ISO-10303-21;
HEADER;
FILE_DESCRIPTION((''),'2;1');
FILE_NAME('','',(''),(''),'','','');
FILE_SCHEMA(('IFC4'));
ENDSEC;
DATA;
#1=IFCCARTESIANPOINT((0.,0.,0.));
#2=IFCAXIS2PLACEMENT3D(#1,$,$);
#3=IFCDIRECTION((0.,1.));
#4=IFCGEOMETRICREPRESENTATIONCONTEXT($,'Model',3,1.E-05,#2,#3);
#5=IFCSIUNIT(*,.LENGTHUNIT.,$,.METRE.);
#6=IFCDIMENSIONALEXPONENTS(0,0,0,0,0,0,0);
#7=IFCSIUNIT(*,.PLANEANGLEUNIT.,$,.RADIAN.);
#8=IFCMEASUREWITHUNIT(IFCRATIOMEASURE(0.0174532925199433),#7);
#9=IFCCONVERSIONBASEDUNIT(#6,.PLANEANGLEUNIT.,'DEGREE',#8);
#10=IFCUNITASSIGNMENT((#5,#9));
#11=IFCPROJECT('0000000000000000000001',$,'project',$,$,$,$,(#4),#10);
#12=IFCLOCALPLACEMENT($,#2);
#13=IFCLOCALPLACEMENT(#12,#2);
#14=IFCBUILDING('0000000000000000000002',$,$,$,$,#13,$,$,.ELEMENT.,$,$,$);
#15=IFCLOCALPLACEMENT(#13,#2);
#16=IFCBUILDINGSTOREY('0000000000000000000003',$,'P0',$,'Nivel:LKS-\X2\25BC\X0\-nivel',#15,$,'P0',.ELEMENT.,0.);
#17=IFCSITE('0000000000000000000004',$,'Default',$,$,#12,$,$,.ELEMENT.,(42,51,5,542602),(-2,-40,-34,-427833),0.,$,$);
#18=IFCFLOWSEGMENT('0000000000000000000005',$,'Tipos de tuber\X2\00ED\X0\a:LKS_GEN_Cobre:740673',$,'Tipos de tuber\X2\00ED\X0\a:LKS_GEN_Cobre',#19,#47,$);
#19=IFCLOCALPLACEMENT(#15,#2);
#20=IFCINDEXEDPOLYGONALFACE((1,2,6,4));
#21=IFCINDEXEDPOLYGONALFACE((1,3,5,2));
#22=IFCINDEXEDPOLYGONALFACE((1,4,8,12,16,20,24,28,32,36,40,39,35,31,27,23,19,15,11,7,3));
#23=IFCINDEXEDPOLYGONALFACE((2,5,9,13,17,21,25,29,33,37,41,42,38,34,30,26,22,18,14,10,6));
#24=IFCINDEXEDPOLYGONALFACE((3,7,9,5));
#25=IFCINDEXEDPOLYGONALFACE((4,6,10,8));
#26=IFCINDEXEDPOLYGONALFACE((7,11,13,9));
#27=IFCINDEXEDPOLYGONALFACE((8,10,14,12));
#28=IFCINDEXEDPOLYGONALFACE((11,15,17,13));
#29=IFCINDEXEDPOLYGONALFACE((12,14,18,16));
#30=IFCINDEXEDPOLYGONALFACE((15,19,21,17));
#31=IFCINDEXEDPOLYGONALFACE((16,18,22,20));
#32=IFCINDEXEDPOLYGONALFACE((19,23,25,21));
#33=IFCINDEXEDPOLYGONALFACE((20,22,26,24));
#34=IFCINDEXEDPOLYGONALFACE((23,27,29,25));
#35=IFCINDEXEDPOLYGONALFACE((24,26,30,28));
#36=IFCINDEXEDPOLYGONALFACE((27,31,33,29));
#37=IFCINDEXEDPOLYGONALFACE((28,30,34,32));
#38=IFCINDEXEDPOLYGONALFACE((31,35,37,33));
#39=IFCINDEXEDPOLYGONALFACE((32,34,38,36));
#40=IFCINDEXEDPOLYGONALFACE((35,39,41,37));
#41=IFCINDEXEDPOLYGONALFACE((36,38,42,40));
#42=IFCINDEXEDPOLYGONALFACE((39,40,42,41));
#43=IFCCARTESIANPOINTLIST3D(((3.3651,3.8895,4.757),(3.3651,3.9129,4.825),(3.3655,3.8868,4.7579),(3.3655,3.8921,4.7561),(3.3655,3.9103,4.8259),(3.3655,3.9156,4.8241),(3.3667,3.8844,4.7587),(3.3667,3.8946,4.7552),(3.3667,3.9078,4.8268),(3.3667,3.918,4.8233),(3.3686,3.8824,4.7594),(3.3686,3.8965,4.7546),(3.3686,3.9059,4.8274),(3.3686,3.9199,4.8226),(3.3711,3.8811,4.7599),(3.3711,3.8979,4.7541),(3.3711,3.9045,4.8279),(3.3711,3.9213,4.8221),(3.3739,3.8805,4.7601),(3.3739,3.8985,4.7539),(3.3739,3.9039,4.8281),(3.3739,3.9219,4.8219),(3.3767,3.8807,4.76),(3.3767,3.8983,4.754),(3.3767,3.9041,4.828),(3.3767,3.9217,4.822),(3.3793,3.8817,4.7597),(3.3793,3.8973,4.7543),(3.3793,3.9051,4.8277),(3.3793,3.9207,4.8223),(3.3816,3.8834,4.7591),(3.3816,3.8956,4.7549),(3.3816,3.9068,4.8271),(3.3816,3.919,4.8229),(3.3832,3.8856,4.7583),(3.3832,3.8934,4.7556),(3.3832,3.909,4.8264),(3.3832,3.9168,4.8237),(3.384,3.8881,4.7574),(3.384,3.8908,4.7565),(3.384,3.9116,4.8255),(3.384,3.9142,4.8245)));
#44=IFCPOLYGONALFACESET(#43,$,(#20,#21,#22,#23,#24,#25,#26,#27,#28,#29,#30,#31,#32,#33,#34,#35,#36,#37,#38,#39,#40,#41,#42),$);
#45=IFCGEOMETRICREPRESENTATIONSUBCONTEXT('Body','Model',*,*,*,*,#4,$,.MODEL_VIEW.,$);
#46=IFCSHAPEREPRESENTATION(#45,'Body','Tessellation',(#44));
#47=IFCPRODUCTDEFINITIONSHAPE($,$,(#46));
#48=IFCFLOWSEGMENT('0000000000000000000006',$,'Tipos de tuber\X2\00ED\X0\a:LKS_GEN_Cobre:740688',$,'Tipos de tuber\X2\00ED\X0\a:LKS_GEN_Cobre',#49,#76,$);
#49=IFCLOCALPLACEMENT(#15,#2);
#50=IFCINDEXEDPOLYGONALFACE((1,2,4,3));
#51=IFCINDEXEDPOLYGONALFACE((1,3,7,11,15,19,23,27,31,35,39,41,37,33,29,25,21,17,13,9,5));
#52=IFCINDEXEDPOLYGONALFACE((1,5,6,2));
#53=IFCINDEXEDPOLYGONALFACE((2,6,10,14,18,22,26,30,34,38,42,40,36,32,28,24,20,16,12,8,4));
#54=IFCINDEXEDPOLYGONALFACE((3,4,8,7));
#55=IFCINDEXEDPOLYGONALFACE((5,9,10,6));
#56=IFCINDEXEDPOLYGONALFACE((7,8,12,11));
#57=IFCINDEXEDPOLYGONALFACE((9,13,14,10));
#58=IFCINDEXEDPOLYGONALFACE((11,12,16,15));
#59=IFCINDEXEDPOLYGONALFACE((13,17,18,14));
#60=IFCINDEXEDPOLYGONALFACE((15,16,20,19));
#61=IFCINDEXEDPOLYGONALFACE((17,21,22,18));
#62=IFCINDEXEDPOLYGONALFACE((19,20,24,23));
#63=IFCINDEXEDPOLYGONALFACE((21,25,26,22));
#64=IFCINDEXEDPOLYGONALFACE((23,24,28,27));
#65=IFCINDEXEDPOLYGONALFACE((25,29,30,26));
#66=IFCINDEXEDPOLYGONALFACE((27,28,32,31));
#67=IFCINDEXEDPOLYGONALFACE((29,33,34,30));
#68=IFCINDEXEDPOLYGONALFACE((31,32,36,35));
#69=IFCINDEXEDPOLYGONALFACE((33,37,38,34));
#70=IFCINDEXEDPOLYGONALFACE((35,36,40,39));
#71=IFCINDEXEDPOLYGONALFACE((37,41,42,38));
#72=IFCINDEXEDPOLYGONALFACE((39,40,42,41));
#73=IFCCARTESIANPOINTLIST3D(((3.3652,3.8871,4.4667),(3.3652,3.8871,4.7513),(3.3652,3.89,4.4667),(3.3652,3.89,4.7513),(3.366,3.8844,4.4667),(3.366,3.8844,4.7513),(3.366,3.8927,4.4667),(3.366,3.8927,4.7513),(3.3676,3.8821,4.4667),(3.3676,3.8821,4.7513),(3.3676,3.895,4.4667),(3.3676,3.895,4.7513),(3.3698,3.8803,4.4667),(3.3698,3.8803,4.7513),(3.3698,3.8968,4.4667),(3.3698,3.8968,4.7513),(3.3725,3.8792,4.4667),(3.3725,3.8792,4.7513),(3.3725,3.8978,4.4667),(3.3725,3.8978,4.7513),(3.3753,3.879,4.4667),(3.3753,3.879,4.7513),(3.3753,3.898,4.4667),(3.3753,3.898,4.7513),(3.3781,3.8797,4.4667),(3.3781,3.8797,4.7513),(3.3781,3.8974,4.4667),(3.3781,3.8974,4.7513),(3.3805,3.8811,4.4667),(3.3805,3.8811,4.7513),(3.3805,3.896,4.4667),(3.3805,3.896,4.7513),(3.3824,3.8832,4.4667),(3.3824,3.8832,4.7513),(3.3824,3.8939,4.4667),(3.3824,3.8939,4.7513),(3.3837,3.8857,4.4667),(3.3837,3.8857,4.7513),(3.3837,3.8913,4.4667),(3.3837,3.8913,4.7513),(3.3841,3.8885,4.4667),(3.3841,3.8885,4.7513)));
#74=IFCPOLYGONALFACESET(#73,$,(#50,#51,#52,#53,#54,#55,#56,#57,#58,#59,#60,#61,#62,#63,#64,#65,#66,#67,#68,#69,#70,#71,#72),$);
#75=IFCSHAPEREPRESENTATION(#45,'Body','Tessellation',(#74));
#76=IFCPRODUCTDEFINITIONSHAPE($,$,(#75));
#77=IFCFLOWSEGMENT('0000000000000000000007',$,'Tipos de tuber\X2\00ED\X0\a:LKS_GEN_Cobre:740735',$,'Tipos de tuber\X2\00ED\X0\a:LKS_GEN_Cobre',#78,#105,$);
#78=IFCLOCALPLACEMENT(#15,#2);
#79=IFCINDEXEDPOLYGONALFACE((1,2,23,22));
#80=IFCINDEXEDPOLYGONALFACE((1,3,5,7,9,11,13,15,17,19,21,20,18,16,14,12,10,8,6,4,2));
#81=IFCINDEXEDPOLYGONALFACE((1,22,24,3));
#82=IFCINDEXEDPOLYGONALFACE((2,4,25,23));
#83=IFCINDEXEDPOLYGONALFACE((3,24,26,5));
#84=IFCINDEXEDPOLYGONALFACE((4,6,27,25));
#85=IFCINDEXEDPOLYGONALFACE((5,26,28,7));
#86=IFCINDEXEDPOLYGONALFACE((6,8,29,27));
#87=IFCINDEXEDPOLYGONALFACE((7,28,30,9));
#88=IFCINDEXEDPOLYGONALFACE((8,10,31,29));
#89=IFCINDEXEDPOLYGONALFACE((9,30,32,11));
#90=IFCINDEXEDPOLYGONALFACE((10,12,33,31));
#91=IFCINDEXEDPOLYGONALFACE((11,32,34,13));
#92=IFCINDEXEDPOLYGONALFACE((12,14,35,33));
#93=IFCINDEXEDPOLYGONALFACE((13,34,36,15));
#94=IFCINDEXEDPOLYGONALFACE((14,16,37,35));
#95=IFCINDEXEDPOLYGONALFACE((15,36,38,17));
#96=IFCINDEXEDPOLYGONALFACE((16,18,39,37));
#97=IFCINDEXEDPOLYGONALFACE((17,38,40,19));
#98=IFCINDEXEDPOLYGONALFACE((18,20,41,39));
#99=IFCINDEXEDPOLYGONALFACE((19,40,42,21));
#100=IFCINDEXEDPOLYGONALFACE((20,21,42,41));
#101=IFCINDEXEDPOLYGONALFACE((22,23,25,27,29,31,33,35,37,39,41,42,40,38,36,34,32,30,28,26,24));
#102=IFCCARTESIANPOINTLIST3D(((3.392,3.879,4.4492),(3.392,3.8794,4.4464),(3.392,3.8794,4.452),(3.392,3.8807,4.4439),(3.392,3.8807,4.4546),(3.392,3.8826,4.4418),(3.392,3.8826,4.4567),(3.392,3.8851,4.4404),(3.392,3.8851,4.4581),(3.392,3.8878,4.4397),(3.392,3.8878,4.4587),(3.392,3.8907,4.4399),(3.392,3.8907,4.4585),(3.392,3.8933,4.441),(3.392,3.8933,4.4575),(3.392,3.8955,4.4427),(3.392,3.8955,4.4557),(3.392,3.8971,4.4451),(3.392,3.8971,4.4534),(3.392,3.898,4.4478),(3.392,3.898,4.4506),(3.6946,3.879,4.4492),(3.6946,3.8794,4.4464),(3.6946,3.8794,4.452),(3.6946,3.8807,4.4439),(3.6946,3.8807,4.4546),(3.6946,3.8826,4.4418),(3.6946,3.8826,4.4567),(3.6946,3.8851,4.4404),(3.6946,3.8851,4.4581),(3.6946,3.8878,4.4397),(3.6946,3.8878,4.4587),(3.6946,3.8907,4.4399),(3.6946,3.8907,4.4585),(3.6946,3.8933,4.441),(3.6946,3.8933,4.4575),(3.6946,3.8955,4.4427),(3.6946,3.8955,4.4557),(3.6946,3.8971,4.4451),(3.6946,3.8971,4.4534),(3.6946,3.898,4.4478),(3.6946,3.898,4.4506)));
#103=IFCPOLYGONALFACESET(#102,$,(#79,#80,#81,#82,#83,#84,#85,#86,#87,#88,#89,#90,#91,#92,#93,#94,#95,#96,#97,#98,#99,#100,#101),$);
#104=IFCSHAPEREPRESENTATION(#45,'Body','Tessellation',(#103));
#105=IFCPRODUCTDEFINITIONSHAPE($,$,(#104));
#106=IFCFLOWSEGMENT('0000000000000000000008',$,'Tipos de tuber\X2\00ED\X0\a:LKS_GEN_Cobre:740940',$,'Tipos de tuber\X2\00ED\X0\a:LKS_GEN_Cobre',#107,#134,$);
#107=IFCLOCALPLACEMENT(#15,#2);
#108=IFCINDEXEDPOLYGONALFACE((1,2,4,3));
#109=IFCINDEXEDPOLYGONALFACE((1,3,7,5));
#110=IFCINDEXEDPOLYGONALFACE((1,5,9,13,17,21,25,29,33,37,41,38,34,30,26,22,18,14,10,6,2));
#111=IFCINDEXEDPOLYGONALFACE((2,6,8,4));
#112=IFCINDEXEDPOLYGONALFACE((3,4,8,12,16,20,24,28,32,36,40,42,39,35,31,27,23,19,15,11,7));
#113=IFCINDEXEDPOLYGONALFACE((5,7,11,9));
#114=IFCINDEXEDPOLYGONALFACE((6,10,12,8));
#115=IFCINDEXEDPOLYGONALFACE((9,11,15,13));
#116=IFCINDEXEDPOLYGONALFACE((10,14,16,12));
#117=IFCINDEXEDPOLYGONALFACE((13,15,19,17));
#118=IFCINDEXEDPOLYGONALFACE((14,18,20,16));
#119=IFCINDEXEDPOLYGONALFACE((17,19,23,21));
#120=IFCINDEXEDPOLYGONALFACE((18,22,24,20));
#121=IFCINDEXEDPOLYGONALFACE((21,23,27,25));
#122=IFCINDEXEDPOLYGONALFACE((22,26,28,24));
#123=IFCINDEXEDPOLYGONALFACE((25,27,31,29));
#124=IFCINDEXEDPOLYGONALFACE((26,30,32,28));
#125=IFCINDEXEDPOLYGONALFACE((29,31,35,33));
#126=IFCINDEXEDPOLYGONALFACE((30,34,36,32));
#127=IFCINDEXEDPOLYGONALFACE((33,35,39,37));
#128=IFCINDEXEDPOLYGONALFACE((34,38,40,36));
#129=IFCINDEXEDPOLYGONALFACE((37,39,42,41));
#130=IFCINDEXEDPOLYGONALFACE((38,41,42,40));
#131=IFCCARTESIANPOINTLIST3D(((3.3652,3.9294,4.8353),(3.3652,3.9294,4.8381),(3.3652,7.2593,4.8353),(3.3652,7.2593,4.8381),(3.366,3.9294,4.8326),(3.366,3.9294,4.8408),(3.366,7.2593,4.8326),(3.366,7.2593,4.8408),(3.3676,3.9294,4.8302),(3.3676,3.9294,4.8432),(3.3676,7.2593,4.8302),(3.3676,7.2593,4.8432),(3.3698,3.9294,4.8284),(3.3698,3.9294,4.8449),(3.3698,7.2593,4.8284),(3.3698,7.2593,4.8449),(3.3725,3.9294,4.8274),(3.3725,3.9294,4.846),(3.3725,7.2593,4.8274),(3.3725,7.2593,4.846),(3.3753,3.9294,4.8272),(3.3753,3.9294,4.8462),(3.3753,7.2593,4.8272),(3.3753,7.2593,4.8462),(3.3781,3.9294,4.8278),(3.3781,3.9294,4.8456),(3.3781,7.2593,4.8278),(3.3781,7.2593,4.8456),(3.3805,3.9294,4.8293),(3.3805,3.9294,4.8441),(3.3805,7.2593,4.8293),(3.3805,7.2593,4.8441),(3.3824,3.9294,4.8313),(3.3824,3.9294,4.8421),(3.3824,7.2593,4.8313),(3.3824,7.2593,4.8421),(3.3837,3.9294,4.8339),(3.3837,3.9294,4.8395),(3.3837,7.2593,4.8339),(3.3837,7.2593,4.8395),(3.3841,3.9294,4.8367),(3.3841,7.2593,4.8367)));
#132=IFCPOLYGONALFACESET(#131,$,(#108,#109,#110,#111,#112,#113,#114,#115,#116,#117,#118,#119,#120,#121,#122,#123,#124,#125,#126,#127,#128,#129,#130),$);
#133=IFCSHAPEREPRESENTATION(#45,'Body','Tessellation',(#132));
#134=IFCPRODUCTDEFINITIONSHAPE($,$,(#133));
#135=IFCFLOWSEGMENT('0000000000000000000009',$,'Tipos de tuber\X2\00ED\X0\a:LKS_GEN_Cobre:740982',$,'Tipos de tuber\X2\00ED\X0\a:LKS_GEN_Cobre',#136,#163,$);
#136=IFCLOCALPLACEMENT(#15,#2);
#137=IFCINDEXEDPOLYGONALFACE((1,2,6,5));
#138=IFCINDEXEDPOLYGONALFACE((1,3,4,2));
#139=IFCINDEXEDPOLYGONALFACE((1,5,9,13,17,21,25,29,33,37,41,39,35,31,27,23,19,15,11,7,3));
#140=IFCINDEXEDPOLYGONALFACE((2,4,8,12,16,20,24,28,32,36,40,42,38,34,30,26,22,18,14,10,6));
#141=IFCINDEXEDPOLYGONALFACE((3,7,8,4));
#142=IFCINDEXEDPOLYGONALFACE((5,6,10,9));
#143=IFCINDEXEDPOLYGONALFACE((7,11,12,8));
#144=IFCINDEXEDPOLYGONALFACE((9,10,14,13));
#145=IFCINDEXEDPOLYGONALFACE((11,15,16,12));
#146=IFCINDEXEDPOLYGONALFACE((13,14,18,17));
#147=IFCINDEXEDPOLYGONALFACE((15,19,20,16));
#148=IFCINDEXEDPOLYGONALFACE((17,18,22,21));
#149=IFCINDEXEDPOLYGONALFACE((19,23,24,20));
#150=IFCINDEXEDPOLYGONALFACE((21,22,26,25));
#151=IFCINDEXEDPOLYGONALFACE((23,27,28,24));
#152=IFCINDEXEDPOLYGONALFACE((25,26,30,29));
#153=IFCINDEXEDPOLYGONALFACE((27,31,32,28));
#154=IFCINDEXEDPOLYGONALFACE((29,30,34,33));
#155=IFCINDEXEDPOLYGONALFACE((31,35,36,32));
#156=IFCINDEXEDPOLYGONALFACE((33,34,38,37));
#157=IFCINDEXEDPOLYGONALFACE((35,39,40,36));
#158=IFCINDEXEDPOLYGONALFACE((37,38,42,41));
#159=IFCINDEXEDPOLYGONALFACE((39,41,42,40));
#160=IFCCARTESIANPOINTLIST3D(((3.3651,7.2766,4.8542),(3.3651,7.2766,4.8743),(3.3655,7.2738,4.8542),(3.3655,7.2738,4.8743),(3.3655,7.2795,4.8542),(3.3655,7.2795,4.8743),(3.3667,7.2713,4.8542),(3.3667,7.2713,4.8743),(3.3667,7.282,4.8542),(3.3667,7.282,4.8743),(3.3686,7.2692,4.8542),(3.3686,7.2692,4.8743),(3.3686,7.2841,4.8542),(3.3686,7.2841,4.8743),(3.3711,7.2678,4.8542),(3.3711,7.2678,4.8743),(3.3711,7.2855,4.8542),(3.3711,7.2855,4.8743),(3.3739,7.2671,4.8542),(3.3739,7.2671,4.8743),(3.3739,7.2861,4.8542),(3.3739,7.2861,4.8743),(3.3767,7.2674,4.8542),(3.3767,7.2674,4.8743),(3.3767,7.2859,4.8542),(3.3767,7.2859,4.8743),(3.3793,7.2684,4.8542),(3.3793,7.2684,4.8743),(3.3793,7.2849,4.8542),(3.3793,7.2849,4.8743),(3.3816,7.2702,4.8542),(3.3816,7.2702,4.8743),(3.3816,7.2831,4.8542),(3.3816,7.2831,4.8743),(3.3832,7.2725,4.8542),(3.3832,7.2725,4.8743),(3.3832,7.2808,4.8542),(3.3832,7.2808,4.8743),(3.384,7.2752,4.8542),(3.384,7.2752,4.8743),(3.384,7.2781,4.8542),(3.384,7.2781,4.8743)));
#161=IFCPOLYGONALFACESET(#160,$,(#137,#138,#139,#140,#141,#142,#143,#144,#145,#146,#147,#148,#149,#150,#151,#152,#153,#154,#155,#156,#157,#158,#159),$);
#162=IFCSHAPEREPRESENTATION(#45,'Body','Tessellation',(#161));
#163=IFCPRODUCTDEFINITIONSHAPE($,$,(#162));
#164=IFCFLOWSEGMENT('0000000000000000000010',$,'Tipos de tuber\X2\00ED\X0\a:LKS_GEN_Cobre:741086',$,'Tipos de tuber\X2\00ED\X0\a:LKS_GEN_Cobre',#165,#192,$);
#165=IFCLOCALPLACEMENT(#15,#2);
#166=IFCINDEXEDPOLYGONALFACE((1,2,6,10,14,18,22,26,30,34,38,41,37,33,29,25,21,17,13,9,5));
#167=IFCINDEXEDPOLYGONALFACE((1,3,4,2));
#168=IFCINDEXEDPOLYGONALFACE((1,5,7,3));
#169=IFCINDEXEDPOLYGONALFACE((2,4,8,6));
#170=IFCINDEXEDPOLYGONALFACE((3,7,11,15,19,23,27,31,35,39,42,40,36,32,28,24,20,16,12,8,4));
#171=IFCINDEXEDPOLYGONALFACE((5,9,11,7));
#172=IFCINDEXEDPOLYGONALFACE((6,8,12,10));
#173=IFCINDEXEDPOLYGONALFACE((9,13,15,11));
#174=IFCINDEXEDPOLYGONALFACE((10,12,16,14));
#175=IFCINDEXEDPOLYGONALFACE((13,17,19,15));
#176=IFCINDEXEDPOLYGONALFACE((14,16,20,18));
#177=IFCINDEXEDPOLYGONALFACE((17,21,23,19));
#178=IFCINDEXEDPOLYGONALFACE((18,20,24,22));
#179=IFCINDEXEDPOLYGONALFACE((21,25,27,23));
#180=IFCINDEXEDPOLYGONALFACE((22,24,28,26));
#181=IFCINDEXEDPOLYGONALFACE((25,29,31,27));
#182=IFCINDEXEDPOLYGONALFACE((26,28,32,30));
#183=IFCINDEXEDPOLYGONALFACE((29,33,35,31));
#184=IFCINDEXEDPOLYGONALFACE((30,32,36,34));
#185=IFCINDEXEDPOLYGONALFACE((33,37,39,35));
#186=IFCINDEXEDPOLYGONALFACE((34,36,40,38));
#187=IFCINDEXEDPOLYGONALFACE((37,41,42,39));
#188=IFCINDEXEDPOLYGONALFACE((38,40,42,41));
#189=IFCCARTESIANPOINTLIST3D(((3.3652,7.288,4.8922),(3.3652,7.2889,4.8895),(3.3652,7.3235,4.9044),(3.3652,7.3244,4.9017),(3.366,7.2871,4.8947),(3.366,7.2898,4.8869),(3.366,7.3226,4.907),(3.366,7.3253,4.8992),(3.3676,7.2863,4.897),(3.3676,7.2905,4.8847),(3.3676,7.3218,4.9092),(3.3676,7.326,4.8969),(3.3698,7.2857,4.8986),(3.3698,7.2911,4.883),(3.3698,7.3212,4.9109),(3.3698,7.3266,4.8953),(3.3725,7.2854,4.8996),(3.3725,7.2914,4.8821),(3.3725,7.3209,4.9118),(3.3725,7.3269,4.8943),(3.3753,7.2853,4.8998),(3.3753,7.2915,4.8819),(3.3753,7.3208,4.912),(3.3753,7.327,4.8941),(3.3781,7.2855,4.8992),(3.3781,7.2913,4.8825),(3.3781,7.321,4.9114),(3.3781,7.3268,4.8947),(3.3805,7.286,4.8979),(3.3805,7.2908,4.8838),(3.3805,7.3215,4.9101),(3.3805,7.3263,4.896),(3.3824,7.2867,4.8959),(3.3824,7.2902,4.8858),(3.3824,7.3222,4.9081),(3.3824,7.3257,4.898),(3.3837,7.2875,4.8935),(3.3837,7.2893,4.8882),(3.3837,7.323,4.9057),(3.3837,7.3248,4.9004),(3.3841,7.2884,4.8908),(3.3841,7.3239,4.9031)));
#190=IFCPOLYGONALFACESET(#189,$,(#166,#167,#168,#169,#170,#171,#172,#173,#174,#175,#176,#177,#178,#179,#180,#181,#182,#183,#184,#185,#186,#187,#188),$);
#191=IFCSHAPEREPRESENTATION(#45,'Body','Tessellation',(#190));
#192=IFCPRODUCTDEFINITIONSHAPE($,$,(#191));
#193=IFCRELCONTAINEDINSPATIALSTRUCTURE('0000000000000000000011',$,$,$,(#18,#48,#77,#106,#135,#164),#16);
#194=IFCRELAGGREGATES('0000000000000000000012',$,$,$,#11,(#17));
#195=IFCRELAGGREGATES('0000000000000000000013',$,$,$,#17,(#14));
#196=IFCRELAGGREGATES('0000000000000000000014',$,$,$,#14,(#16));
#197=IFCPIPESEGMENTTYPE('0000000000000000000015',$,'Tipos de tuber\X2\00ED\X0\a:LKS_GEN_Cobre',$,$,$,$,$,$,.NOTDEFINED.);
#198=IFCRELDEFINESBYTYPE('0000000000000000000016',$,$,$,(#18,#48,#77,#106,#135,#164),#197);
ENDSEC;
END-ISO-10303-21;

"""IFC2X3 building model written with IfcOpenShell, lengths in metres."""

from ifc_helpers import new_model, entity, si_unit, converted_unit, direction, frame, frame_2d, origin, origin_2d_with_axis, place, context, subcontext, project, spatial, circle, extrude, type_object, element, save


model = new_model("IFC2X3")

# Units and contexts
model_context = context("Model", 3, precision=1e-05, world=origin(), true_north=direction((0.0, 1.0)))
body_context = subcontext(model_context, "Body", "Model", "MODEL_VIEW")
ifc_project = project(units=[si_unit("LENGTHUNIT", "METRE"), converted_unit("PLANEANGLEUNIT", "DEGREE", entity("IfcRatioMeasure", 0.0174532925199433), si_unit("PLANEANGLEUNIT", "RADIAN"), dimensions=[0, 0, 0, 0, 0, 0, 0])], contexts=[model_context])

# Site, building, storey
site_placement = place(None, origin())
site = spatial("IfcSite", under=ifc_project, at=site_placement, Name="Default", CompositionType="ELEMENT", RefLatitude=(42, 51, 5, 542602), RefLongitude=(-2, -40, -34, -427833), RefElevation=0.0)
building_placement = place(site_placement, origin())
building = spatial("IfcBuilding", under=site, at=building_placement, CompositionType="ELEMENT")
storey_placement = place(building_placement, origin())
storey = spatial("IfcBuildingStorey", under=building, at=storey_placement, Name="P0", ObjectType="Nivel:LKS-▼-nivel", LongName="P0", CompositionType="ELEMENT", Elevation=0.0)

# Flow segments
pipe_segment_type = type_object("IfcPipeSegmentType", Name="Tipos de tubería:LKS_GEN_Cobre", PredefinedType="NOTDEFINED")
flow_segment_1_placement = place(storey_placement, origin())
element("IfcFlowSegment", 1, at=flow_segment_1_placement, inside=storey, type_object=pipe_segment_type, Name="Tipos de tubería:LKS_GEN_Cobre:740673", ObjectType="Tipos de tubería:LKS_GEN_Cobre", context=body_context, shape_type="SweptSolid", body=[
    extrude(circle(Radius=0.0095, at=origin_2d_with_axis()), frame((3.3746, 3.8895, 4.757), z_axis=(0.0, 0.325568, 0.945519), x_axis=(-1.0, -0.000001, 0.0)), (0.0, 0.0, 1.0), 0.0719),
])
flow_segment_2_placement = place(storey_placement, origin())
element("IfcFlowSegment", 2, at=flow_segment_2_placement, inside=storey, type_object=pipe_segment_type, Name="Tipos de tubería:LKS_GEN_Cobre:740688", ObjectType="Tipos de tubería:LKS_GEN_Cobre", context=body_context, shape_type="SweptSolid", body=[
    extrude(circle(Radius=0.0095, at=origin_2d_with_axis()), frame((3.3746, 3.8885, 4.4667)), (0.0, 0.0, 1.0), 0.2846),
])
flow_segment_3_placement = place(storey_placement, origin())
element("IfcFlowSegment", 3, at=flow_segment_3_placement, inside=storey, type_object=pipe_segment_type, Name="Tipos de tubería:LKS_GEN_Cobre:740735", ObjectType="Tipos de tubería:LKS_GEN_Cobre", context=body_context, shape_type="SweptSolid", body=[
    extrude(circle(Radius=0.0095, at=origin_2d_with_axis()), frame((3.392, 3.8885, 4.4492), z_axis=(1.0, 0.0, 0.0), x_axis=(0.0, -1.0, 0.0)), (0.0, 0.0, 1.0), 0.3025),
])
flow_segment_4_placement = place(storey_placement, origin())
element("IfcFlowSegment", 4, at=flow_segment_4_placement, inside=storey, type_object=pipe_segment_type, Name="Tipos de tubería:LKS_GEN_Cobre:740940", ObjectType="Tipos de tubería:LKS_GEN_Cobre", context=body_context, shape_type="SweptSolid", body=[
    extrude(circle(Radius=0.0095, at=frame_2d((0.0, 0.0), x_axis=(1.0, 0.0))), frame((3.3746, 3.9294, 4.8367), z_axis=(0.0, 1.0, 0.0), x_axis=(1.0, 0.0, 0.0)), (0.0, 0.0, 1.0), 3.3299),
])
flow_segment_5_placement = place(storey_placement, origin())
element("IfcFlowSegment", 5, at=flow_segment_5_placement, inside=storey, type_object=pipe_segment_type, Name="Tipos de tubería:LKS_GEN_Cobre:740982", ObjectType="Tipos de tubería:LKS_GEN_Cobre", context=body_context, shape_type="SweptSolid", body=[
    extrude(circle(Radius=0.0095, at=origin_2d_with_axis()), frame((3.3746, 7.2766, 4.8542), z_axis=(0.0, 0.0, 1.0), x_axis=(-1.0, 0.0, 0.0)), (0.0, 0.0, 1.0), 0.0202),
])
flow_segment_6_placement = place(storey_placement, origin())
element("IfcFlowSegment", 6, at=flow_segment_6_placement, inside=storey, type_object=pipe_segment_type, Name="Tipos de tubería:LKS_GEN_Cobre:741086", ObjectType="Tipos de tubería:LKS_GEN_Cobre", context=body_context, shape_type="SweptSolid", body=[
    extrude(circle(Radius=0.0095, at=origin_2d_with_axis()), frame((3.3746, 7.2884, 4.8908), z_axis=(0.0, 0.945519, 0.325568), x_axis=(1.0, 0.0, 0.0)), (0.0, 0.0, 1.0), 0.0375),
])

save(model, "model.ifc")
